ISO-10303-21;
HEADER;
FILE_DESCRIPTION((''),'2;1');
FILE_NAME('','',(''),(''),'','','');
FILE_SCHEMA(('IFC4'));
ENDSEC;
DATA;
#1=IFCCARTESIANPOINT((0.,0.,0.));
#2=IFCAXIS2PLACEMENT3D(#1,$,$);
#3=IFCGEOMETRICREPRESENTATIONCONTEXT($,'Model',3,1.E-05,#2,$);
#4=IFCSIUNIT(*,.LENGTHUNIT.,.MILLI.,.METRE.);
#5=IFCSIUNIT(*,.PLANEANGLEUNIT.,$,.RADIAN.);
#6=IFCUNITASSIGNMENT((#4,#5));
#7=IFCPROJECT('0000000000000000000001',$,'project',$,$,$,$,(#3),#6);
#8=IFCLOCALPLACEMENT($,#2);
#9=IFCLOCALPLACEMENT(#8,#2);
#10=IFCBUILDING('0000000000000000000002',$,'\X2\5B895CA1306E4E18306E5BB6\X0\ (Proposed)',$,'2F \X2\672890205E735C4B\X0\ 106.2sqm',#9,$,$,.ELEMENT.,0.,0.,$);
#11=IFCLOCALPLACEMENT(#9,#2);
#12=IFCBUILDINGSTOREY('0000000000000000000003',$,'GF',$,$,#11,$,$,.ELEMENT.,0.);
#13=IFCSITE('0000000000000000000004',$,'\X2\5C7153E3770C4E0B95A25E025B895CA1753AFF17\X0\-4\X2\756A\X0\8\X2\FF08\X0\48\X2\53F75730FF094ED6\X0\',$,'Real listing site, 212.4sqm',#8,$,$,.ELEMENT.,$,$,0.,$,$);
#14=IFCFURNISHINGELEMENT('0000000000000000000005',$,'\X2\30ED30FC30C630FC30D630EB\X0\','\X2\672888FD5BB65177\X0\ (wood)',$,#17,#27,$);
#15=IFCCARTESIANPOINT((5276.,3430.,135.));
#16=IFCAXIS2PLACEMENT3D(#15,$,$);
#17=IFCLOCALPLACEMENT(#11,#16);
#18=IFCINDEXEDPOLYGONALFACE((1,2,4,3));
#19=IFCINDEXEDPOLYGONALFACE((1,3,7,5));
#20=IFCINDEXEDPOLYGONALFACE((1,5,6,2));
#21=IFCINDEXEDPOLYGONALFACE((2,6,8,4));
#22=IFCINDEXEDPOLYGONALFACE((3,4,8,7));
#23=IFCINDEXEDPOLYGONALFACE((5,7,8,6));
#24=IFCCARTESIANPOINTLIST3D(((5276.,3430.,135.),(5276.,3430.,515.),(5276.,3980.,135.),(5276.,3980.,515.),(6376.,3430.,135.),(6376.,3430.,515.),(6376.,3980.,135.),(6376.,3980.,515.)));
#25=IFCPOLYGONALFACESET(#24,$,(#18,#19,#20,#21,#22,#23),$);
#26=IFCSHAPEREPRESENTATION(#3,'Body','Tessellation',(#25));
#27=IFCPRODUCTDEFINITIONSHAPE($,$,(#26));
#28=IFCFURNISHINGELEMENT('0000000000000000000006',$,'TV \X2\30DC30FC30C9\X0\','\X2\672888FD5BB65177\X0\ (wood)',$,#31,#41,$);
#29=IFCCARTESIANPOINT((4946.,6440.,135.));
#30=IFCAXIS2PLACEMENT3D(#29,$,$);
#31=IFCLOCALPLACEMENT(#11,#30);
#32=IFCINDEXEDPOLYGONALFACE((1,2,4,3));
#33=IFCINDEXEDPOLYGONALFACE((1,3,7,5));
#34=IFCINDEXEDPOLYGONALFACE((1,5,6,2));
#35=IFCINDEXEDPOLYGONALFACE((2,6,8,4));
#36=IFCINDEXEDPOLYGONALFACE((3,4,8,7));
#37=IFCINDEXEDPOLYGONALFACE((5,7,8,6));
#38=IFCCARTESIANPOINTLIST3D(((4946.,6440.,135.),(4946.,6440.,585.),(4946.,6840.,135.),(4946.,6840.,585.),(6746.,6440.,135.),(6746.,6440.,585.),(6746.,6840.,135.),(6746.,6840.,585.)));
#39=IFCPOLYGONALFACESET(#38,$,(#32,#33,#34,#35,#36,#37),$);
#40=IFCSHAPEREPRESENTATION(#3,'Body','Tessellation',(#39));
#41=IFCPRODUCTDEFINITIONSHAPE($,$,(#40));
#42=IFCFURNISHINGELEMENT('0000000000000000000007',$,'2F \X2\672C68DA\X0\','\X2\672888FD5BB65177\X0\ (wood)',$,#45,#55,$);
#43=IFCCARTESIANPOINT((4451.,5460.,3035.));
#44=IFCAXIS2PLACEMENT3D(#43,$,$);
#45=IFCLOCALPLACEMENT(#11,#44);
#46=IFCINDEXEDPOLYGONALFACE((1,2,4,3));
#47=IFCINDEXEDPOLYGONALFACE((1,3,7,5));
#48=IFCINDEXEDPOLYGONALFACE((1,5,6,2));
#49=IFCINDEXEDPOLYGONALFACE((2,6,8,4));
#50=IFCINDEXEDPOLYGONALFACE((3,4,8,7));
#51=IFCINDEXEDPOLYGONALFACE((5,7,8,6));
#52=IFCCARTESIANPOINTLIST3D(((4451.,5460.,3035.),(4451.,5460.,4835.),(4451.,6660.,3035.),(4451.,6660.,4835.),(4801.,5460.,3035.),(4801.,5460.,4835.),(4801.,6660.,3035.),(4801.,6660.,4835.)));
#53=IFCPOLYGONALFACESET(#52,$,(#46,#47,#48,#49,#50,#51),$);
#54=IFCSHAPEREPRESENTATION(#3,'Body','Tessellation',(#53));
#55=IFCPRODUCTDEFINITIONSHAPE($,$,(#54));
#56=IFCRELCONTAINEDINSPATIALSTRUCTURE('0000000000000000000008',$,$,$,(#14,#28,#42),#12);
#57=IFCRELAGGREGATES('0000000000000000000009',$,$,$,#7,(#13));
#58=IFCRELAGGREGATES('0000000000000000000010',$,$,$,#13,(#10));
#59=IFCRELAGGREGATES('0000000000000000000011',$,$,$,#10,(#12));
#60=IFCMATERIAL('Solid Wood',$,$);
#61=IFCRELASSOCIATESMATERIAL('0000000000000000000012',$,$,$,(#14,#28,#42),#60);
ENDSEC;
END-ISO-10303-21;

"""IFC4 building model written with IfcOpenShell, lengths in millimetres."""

from ifc_helpers import new_model, si_unit, frame, frame_2d, origin, place, context, project, spatial, rectangle, extrude, material, element, save


model = new_model("IFC4")

# Units and contexts
model_context = context("Model", 3, precision=1e-05, world=origin())
ifc_project = project(units=[si_unit("LENGTHUNIT", "METRE", prefix="MILLI"), si_unit("PLANEANGLEUNIT", "RADIAN")], contexts=[model_context])

# Site, building, storey
site_placement = place(None, origin())
site = spatial("IfcSite", under=ifc_project, at=site_placement, Name="山口県下関市安岡町７-4番8（48号地）他", ObjectType="Real listing site, 212.4sqm", CompositionType="ELEMENT", RefElevation=0.0)
building_placement = place(site_placement, origin())
building = spatial("IfcBuilding", under=site, at=building_placement, Name="安岡の丘の家 (Proposed)", ObjectType="2F 木造平屋 106.2sqm", CompositionType="ELEMENT", ElevationOfRefHeight=0.0, ElevationOfTerrain=0.0)
storey_placement = place(building_placement, origin())
storey = spatial("IfcBuildingStorey", under=building, at=storey_placement, Name="GF", CompositionType="ELEMENT", Elevation=0.0)

# Shared definitions
ifc_material_1 = material(Name="Solid Wood")

# Furnishing elements
furnishing_1_placement = place(storey_placement, frame((5276.0, 3430.0, 135.0)))
element("IfcFurnishingElement", 1, at=furnishing_1_placement, inside=storey, material=ifc_material_1, Name="ローテーブル", Description="木製家具 (wood)", context=model_context, shape_type="SweptSolid", body=[
    extrude(rectangle(XDim=1100.0, YDim=550.0, at=frame_2d((550.0, 275.0))), frame((5276.0, 3430.0, 135.0)), (0.0, 0.0, 1.0), 380.0),
])
furnishing_2_placement = place(storey_placement, frame((4946.0, 6440.0, 135.0)))
element("IfcFurnishingElement", 2, at=furnishing_2_placement, inside=storey, material=ifc_material_1, Name="TV ボード", Description="木製家具 (wood)", context=model_context, shape_type="SweptSolid", body=[
    extrude(rectangle(XDim=1800.0, YDim=400.0, at=frame_2d((900.0, 200.0))), frame((4946.0, 6440.0, 135.0)), (0.0, 0.0, 1.0), 450.0),
])
furnishing_3_placement = place(storey_placement, frame((4451.0, 5460.0, 3035.0)))
element("IfcFurnishingElement", 3, at=furnishing_3_placement, inside=storey, material=ifc_material_1, Name="2F 本棚", Description="木製家具 (wood)", context=model_context, shape_type="SweptSolid", body=[
    extrude(rectangle(XDim=350.0, YDim=1200.0, at=frame_2d((175.0, 600.0))), frame((4451.0, 5460.0, 3035.0)), (0.0, 0.0, 1.0), 1800.0),
])

save(model, "model.ifc")
